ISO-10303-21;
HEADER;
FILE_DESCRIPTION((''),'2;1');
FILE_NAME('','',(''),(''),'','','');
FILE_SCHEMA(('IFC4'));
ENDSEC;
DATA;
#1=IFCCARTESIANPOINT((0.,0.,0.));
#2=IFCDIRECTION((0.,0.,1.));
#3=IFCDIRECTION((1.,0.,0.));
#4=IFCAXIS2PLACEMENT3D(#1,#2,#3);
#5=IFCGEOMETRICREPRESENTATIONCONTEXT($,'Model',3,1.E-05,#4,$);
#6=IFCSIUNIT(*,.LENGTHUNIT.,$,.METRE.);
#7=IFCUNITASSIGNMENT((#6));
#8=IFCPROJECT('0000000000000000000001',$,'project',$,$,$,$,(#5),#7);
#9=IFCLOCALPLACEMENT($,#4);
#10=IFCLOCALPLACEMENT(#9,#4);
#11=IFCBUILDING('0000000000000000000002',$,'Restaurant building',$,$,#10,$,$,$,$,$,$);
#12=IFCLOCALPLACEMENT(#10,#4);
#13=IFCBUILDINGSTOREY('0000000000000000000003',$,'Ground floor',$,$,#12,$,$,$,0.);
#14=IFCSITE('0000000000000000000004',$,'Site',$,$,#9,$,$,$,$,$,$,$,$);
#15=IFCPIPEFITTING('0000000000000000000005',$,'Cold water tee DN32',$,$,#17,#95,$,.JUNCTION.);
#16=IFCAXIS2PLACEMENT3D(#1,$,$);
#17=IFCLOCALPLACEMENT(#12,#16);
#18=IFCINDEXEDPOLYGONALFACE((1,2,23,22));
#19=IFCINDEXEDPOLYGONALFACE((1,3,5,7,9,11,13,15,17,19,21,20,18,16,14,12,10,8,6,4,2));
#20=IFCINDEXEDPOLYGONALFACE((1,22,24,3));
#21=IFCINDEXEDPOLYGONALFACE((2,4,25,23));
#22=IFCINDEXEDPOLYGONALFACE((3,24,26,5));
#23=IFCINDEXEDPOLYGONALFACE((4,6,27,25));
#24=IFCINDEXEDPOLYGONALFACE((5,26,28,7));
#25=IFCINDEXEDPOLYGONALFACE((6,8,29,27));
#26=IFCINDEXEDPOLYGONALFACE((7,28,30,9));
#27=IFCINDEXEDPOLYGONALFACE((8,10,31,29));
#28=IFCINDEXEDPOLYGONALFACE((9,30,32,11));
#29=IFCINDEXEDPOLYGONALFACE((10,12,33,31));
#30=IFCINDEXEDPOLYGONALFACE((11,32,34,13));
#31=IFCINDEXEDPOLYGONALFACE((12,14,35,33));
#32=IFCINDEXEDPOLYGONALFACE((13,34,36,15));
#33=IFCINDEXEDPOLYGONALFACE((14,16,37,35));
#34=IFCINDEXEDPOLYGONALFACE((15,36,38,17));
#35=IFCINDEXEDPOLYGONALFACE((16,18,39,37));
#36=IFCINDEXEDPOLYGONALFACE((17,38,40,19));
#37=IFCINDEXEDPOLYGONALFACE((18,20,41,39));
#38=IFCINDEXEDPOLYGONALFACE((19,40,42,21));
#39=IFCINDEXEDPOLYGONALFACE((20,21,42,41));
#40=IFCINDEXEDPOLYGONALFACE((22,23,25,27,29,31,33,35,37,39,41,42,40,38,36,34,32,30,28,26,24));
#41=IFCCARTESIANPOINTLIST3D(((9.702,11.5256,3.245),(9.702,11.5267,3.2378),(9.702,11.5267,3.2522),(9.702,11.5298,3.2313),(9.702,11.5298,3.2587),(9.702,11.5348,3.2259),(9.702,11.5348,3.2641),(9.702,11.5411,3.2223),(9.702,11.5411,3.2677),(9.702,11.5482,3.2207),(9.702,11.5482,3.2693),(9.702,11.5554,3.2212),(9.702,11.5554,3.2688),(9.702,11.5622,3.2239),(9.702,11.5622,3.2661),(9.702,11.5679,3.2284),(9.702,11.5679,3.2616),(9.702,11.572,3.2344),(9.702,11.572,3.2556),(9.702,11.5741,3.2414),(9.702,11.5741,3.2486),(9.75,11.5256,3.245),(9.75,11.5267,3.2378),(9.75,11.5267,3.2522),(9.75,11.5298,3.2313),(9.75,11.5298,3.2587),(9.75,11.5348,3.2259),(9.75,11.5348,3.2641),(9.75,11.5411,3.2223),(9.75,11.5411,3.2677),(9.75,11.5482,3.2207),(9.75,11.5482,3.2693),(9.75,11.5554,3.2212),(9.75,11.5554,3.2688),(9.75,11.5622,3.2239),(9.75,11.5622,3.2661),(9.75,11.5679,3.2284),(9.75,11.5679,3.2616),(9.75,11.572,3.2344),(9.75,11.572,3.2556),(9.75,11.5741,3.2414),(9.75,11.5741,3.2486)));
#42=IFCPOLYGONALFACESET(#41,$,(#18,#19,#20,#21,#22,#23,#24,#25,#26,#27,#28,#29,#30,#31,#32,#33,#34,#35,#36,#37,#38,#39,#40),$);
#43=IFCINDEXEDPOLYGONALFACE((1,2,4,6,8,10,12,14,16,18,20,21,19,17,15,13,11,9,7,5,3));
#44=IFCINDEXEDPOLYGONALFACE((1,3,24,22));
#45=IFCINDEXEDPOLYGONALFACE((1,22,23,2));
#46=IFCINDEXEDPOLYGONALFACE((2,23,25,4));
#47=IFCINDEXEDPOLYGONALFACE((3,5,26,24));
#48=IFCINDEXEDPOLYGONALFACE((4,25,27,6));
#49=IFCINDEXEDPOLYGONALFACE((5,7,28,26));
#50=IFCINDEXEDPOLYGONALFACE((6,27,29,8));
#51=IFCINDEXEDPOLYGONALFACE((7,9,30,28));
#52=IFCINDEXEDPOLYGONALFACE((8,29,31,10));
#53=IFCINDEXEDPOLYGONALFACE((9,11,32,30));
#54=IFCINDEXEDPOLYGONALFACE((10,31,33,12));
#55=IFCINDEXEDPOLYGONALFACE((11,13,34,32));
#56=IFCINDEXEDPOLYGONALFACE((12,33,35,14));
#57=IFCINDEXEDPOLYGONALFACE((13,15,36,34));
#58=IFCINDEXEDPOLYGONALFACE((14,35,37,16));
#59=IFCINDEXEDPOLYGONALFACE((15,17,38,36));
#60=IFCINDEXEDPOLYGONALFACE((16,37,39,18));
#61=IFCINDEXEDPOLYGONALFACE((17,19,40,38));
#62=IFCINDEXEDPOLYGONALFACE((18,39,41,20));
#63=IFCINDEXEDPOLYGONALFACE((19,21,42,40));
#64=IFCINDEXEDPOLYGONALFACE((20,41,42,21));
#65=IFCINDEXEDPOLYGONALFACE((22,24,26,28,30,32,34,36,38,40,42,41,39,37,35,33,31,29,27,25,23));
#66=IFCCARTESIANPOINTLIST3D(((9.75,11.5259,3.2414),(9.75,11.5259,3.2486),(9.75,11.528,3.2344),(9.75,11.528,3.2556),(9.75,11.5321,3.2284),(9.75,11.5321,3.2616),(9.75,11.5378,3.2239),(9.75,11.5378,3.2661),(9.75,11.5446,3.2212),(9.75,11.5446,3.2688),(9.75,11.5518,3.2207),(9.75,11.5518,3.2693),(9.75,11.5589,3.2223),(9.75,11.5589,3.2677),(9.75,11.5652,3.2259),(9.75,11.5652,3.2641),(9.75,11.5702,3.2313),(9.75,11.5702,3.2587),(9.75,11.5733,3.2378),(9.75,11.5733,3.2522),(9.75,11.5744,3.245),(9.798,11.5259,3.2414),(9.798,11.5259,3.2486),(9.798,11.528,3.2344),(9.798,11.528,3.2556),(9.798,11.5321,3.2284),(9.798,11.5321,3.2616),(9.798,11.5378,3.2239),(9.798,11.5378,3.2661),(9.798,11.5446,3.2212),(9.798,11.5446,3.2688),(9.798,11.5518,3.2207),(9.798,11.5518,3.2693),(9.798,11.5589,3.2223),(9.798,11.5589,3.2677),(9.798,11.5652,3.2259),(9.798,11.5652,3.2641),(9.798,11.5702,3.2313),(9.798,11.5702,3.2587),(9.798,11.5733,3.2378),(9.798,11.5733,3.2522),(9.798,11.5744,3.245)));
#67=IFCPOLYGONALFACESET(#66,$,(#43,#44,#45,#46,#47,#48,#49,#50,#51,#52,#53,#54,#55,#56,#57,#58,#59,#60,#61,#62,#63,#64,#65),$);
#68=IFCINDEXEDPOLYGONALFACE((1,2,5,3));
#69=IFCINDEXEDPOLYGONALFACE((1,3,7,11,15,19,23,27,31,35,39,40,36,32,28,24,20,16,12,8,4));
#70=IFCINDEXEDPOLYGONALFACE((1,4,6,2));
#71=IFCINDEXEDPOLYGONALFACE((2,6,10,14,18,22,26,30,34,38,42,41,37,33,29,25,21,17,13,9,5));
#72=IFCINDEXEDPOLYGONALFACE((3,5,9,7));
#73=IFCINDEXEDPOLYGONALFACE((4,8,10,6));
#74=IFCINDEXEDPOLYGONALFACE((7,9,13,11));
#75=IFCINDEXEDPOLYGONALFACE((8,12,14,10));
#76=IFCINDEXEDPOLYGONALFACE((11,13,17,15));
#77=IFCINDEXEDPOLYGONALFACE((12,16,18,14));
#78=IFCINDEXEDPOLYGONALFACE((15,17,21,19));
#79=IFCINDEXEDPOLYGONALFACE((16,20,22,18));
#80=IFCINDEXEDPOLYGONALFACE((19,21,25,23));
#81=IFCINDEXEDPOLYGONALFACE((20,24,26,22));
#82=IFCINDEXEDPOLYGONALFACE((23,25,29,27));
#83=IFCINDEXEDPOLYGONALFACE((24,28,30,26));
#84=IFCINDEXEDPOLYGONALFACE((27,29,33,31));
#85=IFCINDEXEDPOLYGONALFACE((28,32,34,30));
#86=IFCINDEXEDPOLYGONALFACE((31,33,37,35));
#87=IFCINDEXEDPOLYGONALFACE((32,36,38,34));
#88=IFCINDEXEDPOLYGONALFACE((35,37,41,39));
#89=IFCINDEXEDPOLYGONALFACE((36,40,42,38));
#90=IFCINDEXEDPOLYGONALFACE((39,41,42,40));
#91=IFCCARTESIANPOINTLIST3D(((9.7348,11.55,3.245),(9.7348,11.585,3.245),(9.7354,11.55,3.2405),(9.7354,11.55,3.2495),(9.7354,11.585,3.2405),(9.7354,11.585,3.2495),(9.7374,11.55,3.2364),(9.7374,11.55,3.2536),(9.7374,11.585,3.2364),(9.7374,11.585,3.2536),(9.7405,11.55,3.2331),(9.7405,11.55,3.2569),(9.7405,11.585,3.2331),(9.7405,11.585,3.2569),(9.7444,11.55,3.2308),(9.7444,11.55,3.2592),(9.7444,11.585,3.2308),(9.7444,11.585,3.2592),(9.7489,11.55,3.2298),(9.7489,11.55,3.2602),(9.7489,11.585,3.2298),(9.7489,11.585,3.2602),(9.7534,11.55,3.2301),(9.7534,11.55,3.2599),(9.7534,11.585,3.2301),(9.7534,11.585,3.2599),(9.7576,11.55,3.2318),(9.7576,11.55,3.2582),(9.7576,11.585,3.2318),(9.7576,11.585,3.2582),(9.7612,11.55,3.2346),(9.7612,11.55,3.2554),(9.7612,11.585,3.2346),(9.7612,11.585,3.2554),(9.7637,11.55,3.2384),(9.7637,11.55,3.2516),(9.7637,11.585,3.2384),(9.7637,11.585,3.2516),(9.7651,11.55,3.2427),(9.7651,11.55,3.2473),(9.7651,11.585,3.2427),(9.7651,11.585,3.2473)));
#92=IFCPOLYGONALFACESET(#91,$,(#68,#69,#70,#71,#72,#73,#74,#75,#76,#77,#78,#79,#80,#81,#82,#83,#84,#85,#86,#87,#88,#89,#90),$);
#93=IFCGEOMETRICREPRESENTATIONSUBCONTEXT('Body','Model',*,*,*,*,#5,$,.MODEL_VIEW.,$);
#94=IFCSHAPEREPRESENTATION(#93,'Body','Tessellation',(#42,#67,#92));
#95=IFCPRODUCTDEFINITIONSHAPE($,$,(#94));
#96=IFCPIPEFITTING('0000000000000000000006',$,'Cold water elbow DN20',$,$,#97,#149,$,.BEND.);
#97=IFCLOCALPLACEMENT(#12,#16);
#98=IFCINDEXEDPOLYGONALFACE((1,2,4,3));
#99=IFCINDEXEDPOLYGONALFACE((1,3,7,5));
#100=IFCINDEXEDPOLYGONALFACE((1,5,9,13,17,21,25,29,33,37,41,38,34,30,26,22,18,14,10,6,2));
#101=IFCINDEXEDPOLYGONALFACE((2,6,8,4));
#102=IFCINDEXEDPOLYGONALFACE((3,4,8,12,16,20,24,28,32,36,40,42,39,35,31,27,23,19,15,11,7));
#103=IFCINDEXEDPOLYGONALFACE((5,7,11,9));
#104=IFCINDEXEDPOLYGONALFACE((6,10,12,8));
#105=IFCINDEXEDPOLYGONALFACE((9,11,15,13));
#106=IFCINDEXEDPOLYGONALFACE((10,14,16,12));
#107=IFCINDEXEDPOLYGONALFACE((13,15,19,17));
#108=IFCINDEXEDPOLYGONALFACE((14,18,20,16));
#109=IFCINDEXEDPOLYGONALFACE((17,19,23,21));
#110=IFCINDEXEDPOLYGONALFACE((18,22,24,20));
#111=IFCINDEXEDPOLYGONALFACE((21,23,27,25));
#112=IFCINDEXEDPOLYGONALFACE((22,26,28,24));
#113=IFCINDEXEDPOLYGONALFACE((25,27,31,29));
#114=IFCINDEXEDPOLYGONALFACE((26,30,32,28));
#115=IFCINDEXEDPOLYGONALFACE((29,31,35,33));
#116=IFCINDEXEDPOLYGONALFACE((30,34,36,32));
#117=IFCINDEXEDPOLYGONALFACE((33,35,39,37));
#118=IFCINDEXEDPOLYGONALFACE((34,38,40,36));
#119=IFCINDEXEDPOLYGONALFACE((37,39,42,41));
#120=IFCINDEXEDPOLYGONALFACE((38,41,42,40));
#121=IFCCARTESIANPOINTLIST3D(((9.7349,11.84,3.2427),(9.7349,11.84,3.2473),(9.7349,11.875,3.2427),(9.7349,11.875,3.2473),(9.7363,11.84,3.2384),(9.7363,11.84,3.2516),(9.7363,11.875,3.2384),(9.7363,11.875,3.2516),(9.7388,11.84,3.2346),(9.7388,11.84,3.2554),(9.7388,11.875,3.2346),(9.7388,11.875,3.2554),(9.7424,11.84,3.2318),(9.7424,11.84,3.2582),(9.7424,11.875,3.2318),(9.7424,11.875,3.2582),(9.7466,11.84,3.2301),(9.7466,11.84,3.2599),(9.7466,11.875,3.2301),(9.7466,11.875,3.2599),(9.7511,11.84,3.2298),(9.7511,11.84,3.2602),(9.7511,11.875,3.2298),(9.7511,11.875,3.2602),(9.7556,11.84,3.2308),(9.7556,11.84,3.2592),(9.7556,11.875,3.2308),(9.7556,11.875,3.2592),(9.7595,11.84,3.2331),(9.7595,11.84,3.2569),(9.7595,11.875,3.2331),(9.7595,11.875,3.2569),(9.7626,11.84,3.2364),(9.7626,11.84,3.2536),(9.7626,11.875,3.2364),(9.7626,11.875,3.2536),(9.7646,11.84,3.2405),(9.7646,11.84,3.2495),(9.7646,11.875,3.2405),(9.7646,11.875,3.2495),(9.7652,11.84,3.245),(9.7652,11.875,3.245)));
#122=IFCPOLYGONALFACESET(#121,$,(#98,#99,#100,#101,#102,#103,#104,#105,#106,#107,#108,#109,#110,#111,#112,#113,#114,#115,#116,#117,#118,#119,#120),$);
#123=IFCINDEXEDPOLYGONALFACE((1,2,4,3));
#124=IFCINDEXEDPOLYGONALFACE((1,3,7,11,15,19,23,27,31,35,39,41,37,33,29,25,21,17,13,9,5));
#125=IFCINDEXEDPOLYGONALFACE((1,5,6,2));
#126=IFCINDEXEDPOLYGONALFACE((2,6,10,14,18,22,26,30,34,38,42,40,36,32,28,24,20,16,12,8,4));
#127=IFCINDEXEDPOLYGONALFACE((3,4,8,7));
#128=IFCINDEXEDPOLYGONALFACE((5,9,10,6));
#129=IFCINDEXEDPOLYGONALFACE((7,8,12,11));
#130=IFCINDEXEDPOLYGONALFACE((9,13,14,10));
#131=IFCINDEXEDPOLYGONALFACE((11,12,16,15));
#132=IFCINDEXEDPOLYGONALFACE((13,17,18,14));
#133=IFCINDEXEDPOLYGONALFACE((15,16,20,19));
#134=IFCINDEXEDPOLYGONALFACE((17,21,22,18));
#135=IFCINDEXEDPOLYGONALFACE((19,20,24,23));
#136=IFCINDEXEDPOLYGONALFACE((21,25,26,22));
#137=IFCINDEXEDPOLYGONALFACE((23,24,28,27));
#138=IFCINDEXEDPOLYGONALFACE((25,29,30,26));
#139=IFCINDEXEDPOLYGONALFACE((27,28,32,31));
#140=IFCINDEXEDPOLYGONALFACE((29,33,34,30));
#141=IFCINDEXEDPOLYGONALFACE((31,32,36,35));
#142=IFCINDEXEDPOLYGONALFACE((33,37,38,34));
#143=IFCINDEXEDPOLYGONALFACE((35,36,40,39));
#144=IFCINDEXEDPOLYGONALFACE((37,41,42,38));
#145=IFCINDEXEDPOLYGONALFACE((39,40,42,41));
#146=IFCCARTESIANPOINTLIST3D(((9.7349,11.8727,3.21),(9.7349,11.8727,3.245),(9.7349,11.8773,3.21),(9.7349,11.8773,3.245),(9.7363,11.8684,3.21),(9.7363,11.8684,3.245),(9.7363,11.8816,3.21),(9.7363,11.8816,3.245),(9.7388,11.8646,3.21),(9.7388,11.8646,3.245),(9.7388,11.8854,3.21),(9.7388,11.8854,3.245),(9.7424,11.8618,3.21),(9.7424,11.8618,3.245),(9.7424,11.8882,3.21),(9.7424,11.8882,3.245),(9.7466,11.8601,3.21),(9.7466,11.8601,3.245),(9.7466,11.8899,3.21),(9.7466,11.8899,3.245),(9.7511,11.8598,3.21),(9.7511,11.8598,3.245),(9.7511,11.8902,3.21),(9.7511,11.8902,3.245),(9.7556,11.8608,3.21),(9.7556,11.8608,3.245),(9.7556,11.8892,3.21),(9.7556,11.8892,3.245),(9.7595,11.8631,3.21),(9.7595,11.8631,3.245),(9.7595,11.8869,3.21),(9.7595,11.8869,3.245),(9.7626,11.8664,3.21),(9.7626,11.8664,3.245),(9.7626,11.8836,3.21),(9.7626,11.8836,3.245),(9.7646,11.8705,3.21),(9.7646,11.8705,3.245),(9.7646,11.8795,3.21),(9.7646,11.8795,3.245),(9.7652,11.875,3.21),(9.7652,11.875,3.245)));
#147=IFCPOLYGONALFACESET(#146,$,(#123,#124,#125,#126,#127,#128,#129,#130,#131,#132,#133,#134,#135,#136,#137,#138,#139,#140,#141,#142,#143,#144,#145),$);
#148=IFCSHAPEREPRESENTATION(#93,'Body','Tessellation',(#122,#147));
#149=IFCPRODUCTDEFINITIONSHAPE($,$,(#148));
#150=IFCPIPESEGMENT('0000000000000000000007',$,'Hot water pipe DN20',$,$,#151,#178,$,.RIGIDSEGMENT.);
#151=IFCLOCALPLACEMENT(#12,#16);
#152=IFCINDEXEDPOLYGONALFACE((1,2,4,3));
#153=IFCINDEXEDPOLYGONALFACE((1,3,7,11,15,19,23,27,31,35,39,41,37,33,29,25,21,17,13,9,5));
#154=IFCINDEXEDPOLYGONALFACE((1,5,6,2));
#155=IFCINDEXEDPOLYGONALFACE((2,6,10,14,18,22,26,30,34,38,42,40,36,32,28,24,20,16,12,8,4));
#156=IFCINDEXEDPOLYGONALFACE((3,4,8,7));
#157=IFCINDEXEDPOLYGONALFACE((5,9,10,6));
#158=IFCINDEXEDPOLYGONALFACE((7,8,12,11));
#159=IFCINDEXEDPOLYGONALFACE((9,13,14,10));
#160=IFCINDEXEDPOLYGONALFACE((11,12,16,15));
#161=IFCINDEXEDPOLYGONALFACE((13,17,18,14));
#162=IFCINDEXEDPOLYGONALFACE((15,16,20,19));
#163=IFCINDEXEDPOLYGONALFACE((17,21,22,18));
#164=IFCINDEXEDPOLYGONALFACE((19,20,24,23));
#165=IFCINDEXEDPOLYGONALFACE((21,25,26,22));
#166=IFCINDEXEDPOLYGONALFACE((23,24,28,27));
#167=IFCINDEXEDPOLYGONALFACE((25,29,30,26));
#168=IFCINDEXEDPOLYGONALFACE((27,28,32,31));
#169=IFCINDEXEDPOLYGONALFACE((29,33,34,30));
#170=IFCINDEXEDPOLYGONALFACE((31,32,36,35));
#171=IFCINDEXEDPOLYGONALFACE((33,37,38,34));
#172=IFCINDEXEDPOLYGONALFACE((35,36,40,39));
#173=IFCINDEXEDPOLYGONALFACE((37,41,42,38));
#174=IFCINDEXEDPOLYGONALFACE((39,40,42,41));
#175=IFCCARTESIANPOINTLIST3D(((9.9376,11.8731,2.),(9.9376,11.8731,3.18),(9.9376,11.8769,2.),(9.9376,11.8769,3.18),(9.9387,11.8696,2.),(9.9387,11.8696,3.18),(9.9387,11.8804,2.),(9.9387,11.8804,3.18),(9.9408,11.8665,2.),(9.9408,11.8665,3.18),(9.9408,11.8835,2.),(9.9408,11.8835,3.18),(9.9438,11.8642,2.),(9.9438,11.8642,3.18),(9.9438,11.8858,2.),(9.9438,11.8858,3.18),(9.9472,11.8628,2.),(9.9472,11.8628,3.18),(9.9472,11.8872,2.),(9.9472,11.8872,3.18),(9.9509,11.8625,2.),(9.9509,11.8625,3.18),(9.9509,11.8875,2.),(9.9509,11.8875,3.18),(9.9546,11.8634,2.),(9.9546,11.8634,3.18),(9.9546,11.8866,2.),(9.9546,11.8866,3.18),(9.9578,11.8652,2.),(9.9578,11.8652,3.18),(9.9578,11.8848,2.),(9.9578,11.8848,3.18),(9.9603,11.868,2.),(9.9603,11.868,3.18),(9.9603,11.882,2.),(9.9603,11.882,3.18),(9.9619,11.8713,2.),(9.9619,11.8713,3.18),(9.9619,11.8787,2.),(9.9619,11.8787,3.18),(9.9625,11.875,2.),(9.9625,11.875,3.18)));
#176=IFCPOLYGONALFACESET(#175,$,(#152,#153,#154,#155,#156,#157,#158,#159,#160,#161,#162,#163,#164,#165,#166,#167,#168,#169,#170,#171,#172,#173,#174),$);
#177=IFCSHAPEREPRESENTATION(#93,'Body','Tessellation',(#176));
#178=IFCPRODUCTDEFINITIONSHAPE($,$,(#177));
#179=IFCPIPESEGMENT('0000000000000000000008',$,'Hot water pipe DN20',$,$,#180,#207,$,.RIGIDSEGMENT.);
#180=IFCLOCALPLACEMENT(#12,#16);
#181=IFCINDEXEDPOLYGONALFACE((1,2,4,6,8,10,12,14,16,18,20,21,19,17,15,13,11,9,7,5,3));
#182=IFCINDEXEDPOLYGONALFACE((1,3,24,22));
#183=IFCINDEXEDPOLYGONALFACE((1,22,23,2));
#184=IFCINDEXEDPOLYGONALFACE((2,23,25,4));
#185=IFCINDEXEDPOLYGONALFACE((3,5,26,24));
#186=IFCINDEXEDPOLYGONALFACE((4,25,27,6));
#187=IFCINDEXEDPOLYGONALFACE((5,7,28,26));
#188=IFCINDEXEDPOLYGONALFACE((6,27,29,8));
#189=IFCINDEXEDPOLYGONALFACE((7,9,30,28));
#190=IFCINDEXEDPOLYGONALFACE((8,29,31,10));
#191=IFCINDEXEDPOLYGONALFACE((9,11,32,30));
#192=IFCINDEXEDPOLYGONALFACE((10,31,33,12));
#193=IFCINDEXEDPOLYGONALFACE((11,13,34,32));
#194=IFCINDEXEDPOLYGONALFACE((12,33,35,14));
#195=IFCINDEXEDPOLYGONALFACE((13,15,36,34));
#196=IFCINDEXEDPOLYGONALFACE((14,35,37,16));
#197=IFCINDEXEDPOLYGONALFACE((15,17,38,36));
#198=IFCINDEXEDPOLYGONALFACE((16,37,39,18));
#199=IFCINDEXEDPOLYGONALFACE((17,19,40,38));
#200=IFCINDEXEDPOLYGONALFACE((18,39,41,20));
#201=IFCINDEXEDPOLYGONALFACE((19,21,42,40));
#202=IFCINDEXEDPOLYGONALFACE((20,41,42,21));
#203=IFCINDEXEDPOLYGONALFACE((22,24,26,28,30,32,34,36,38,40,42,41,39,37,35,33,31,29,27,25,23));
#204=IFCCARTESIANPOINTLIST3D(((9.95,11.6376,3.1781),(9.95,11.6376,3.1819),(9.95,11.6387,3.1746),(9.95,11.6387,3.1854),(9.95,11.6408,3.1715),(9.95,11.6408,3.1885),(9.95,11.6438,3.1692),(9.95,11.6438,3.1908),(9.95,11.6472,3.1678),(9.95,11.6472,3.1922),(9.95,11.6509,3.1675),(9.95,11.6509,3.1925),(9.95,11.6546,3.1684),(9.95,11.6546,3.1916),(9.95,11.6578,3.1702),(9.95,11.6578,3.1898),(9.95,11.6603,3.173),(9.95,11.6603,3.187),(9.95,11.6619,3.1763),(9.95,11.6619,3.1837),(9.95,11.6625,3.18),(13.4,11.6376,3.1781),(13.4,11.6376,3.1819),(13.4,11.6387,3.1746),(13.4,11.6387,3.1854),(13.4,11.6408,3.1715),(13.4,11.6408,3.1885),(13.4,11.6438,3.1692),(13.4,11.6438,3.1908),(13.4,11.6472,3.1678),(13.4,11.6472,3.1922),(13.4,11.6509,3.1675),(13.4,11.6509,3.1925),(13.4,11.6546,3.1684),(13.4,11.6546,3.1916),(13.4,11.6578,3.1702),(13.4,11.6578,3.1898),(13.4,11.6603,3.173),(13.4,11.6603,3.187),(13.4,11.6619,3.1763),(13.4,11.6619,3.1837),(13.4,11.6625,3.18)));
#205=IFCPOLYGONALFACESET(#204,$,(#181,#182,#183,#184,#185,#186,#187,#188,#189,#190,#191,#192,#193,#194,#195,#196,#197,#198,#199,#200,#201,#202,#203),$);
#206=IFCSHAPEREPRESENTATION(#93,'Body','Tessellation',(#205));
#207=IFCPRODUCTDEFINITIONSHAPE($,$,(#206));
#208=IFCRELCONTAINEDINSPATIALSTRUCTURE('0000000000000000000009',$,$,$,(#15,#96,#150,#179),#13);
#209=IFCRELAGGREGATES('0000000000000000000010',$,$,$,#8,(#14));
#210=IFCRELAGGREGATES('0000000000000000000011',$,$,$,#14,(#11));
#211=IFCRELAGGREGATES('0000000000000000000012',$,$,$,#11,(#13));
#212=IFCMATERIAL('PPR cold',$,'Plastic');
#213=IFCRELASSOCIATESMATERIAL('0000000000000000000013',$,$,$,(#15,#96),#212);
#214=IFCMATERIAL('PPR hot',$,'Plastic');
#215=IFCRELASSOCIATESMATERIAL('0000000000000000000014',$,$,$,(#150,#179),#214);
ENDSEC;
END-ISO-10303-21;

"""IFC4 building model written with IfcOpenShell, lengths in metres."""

from ifc_helpers import new_model, si_unit, frame, origin, origin_with_axes, origin_2d, place, context, subcontext, project, spatial, circle, extrude, material, element, save


model = new_model("IFC4")

# Units and contexts
model_context = context("Model", 3, precision=1e-05, world=origin_with_axes())
body_context = subcontext(model_context, "Body", "Model", "MODEL_VIEW")
ifc_project = project(units=[si_unit("LENGTHUNIT", "METRE")], contexts=[model_context])

# Site, building, storey
site_placement = place(None, origin_with_axes())
site = spatial("IfcSite", under=ifc_project, at=site_placement, Name="Site")
building_placement = place(site_placement, origin_with_axes())
building = spatial("IfcBuilding", under=site, at=building_placement, Name="Restaurant building")
storey_placement = place(building_placement, origin_with_axes())
storey = spatial("IfcBuildingStorey", under=building, at=storey_placement, Name="Ground floor", Elevation=0.0)

# Shared definitions
ifc_material_1 = material(Name="PPR cold", Category="Plastic")

# Pipe fittings
pipe_fitting_1_placement = place(storey_placement, frame((9.75, 11.55, 3.245)))
element("IfcPipeFitting", 1, at=pipe_fitting_1_placement, inside=storey, material=ifc_material_1, Name="Cold water tee DN32", PredefinedType="JUNCTION", context=body_context, shape_type="SweptSolid", body=[
    extrude(circle(Radius=0.0244, at=origin_2d()), frame((0.0, 0.0, 0.0), z_axis=(-1.0, 0.0, 0.0), x_axis=(0.0, -1.0, 0.0)), (0.0, 0.0, 1.0), 0.048),
    extrude(circle(Radius=0.0244, at=origin_2d()), frame((0.0, 0.0, 0.0), z_axis=(1.0, 0.0, 0.0), x_axis=(0.0, 1.0, 0.0)), (0.0, 0.0, 1.0), 0.048),
    extrude(circle(Radius=0.0152, at=origin_2d()), frame((0.0, 0.0, 0.0), z_axis=(0.0, 1.0, 0.0), x_axis=(-1.0, 0.0, 0.0)), (0.0, 0.0, 1.0), 0.035),
])
pipe_fitting_2_placement = place(storey_placement, frame((9.75, 11.875, 3.245)))
element("IfcPipeFitting", 2, at=pipe_fitting_2_placement, inside=storey, material=ifc_material_1, Name="Cold water elbow DN20", PredefinedType="BEND", context=body_context, shape_type="SweptSolid", body=[
    extrude(circle(Radius=0.0152, at=origin_2d()), frame((0.0, 0.0, 0.0), z_axis=(0.0, -1.0, 0.0), x_axis=(1.0, 0.0, 0.0)), (0.0, 0.0, 1.0), 0.035),
    extrude(circle(Radius=0.0152, at=origin_2d()), frame((0.0, 0.0, 0.0), z_axis=(0.0, 0.0, -1.0), x_axis=(1.0, 0.0, 0.0)), (0.0, 0.0, 1.0), 0.035),
])

# Pipe segments
ifc_material_2 = material(Name="PPR hot", Category="Plastic")
pipe_segment_1_placement = place(storey_placement, frame((9.95, 11.875, 2.0)))
element("IfcPipeSegment", 3, at=pipe_segment_1_placement, inside=storey, material=ifc_material_2, Name="Hot water pipe DN20", PredefinedType="RIGIDSEGMENT", context=body_context, shape_type="SweptSolid", body=[
    extrude(circle(Radius=0.0125, at=origin_2d()), origin(), (0.0, 0.0, 1.0), 1.18),
])
pipe_segment_2_placement = place(storey_placement, frame((9.95, 11.65, 3.18)))
element("IfcPipeSegment", 4, at=pipe_segment_2_placement, inside=storey, material=ifc_material_2, Name="Hot water pipe DN20", PredefinedType="RIGIDSEGMENT", context=body_context, shape_type="SweptSolid", body=[
    extrude(circle(Radius=0.0125, at=origin_2d()), frame((0.0, 0.0, 0.0), z_axis=(1.0, 0.0, 0.0), x_axis=(0.0, 1.0, 0.0)), (0.0, 0.0, 1.0), 3.45),
])

save(model, "model.ifc")
